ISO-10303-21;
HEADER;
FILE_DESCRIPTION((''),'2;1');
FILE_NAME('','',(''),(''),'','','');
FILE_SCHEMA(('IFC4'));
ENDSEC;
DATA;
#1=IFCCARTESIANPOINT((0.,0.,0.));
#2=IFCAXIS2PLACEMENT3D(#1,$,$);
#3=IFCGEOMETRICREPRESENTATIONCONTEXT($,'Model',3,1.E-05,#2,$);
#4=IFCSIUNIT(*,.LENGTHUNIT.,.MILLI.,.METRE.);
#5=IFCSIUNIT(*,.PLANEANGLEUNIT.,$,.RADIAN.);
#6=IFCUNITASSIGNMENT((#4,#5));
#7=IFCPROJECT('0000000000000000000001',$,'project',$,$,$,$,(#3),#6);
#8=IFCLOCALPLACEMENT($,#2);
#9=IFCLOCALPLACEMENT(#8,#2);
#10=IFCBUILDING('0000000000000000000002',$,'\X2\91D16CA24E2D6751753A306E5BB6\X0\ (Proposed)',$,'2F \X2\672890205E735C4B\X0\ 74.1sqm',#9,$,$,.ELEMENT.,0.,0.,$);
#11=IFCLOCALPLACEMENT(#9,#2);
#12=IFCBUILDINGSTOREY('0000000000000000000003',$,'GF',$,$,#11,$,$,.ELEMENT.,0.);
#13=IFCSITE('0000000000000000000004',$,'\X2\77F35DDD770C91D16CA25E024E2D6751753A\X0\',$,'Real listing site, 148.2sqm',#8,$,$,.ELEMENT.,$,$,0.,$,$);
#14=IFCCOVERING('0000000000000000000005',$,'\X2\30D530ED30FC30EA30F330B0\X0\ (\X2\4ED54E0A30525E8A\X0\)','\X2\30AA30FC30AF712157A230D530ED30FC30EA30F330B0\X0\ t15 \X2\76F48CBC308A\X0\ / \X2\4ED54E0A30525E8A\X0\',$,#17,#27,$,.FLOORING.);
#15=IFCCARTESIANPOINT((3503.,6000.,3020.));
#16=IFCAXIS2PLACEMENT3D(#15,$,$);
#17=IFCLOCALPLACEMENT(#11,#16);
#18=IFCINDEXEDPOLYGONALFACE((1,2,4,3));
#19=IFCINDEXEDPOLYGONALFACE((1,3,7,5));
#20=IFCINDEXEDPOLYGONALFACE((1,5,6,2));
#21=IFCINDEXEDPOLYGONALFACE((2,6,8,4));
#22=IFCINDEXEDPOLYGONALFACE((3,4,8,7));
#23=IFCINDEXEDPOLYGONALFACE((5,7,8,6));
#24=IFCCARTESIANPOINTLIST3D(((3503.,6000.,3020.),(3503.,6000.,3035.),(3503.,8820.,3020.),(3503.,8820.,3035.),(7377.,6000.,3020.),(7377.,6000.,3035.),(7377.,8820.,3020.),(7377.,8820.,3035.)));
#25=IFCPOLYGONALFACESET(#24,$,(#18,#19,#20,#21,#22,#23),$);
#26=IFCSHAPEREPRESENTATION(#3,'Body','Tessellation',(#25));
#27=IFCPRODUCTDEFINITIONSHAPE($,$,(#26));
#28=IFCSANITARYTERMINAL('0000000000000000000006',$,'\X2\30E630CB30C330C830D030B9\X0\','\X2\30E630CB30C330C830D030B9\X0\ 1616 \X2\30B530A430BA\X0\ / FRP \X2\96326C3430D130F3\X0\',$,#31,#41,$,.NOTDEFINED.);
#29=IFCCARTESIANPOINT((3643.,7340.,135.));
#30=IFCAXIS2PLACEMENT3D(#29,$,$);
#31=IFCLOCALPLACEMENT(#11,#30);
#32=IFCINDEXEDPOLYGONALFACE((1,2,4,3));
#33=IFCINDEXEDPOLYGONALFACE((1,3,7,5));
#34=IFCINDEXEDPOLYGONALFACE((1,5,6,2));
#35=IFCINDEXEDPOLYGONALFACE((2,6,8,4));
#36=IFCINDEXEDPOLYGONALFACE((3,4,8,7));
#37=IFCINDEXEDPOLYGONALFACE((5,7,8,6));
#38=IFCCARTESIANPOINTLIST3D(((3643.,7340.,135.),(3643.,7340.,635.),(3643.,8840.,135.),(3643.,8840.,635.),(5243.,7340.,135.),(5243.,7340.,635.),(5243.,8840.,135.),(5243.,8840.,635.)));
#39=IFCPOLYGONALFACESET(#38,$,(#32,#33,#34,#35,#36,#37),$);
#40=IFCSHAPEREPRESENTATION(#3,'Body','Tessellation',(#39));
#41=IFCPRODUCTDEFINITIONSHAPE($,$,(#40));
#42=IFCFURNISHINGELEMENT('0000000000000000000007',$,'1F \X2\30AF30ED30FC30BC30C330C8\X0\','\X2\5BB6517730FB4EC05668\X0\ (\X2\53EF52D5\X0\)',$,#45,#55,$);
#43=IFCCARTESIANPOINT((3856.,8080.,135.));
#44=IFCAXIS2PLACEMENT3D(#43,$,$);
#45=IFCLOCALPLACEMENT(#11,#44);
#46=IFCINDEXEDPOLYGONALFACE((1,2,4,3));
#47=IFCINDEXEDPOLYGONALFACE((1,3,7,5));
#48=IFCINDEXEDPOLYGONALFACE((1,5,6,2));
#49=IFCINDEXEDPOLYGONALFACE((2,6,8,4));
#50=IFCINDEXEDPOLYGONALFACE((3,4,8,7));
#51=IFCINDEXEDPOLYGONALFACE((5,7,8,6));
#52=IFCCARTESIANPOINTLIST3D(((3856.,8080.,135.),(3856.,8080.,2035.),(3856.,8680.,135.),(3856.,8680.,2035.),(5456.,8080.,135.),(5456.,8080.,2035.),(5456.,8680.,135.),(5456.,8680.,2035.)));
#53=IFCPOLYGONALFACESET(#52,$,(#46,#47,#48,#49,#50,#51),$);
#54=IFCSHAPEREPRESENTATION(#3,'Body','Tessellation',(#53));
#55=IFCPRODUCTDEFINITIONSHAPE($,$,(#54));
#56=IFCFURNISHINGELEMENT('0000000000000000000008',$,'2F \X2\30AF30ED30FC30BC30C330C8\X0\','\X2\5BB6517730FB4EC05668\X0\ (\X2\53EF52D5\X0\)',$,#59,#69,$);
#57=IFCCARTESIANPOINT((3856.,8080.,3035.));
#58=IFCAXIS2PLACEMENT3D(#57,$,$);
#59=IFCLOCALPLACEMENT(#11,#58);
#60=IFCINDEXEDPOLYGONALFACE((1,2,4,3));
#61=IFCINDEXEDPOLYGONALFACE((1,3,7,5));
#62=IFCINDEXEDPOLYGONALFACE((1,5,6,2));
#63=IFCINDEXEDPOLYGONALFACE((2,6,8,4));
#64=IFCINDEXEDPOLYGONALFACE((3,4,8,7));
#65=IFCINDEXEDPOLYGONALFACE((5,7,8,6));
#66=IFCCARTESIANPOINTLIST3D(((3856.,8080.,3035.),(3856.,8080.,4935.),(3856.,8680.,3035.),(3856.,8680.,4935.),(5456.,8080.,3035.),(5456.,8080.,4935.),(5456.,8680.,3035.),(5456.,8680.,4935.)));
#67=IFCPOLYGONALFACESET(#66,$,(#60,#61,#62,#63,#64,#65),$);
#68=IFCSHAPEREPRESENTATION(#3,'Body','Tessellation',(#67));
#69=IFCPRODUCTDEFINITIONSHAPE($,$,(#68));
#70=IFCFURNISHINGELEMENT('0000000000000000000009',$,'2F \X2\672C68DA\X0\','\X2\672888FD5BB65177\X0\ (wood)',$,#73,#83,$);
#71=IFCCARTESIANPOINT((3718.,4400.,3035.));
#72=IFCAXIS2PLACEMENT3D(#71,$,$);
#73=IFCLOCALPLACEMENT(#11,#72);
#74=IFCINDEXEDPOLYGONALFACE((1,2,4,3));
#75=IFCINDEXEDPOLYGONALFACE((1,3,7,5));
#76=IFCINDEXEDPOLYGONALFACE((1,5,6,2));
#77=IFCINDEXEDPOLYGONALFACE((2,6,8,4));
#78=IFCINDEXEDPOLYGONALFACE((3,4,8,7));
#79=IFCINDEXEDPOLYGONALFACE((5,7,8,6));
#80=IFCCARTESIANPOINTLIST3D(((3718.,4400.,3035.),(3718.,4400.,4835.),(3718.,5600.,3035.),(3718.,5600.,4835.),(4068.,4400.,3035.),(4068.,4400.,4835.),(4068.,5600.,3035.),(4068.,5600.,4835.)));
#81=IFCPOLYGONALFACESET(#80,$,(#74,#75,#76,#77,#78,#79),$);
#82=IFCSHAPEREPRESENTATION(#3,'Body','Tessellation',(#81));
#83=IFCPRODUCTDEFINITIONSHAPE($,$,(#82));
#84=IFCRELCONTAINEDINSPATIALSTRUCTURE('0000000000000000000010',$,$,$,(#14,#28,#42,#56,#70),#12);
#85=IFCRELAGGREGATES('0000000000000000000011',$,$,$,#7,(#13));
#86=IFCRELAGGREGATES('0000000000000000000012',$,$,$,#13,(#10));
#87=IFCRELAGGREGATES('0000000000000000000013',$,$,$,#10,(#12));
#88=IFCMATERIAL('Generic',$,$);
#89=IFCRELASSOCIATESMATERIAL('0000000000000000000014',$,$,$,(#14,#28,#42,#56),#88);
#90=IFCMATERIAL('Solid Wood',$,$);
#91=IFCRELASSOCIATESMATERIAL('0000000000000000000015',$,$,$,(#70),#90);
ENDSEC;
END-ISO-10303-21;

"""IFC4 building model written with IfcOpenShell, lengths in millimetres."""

from ifc_helpers import new_model, si_unit, frame, frame_2d, origin, place, context, project, spatial, rectangle, extrude, material, element, save


model = new_model("IFC4")

# Units and contexts
model_context = context("Model", 3, precision=1e-05, world=origin())
ifc_project = project(units=[si_unit("LENGTHUNIT", "METRE", prefix="MILLI"), si_unit("PLANEANGLEUNIT", "RADIAN")], contexts=[model_context])

# Site, building, storey
site_placement = place(None, origin())
site = spatial("IfcSite", under=ifc_project, at=site_placement, Name="石川県金沢市中村町", ObjectType="Real listing site, 148.2sqm", CompositionType="ELEMENT", RefElevation=0.0)
building_placement = place(site_placement, origin())
building = spatial("IfcBuilding", under=site, at=building_placement, Name="金沢中村町の家 (Proposed)", ObjectType="2F 木造平屋 74.1sqm", CompositionType="ELEMENT", ElevationOfRefHeight=0.0, ElevationOfTerrain=0.0)
storey_placement = place(building_placement, origin())
storey = spatial("IfcBuildingStorey", under=building, at=storey_placement, Name="GF", CompositionType="ELEMENT", Elevation=0.0)

# Shared definitions
ifc_material_1 = material(Name="Solid Wood")

# Covering
ifc_material_2 = material(Name="Generic")
covering_1_placement = place(storey_placement, frame((3503.0, 6000.0, 3020.0)))
element("IfcCovering", 1, at=covering_1_placement, inside=storey, material=ifc_material_2, Name="フローリング (仕上げ床)", Description="オーク無垢フローリング t15 直貼り / 仕上げ床", PredefinedType="FLOORING", context=model_context, shape_type="SweptSolid", body=[
    extrude(rectangle(XDim=3874.0, YDim=2820.0, at=frame_2d((1937.0, 1410.0))), frame((3503.0, 6000.0, 3020.0)), (0.0, 0.0, 1.0), 15.0),
])

# Sanitary terminal
sanitary_terminal_placement = place(storey_placement, frame((3643.0, 7340.0, 135.0)))
element("IfcSanitaryTerminal", 2, at=sanitary_terminal_placement, inside=storey, material=ifc_material_2, Name="ユニットバス", Description="ユニットバス 1616 サイズ / FRP 防水パン", PredefinedType="NOTDEFINED", context=model_context, shape_type="SweptSolid", body=[
    extrude(rectangle(XDim=1600.0, YDim=1500.0, at=frame_2d((800.0, 750.0))), frame((3643.0, 7340.0, 135.0)), (0.0, 0.0, 1.0), 500.0),
])

# Furnishing elements
furnishing_1_placement = place(storey_placement, frame((3856.0, 8080.0, 135.0)))
element("IfcFurnishingElement", 3, at=furnishing_1_placement, inside=storey, material=ifc_material_2, Name="1F クローゼット", Description="家具・什器 (可動)", context=model_context, shape_type="SweptSolid", body=[
    extrude(rectangle(XDim=1600.0, YDim=600.0, at=frame_2d((800.0, 300.0))), frame((3856.0, 8080.0, 135.0)), (0.0, 0.0, 1.0), 1900.0),
])
furnishing_2_placement = place(storey_placement, frame((3856.0, 8080.0, 3035.0)))
element("IfcFurnishingElement", 4, at=furnishing_2_placement, inside=storey, material=ifc_material_2, Name="2F クローゼット", Description="家具・什器 (可動)", context=model_context, shape_type="SweptSolid", body=[
    extrude(rectangle(XDim=1600.0, YDim=600.0, at=frame_2d((800.0, 300.0))), frame((3856.0, 8080.0, 3035.0)), (0.0, 0.0, 1.0), 1900.0),
])
furnishing_3_placement = place(storey_placement, frame((3718.0, 4400.0, 3035.0)))
element("IfcFurnishingElement", 5, at=furnishing_3_placement, inside=storey, material=ifc_material_1, Name="2F 本棚", Description="木製家具 (wood)", context=model_context, shape_type="SweptSolid", body=[
    extrude(rectangle(XDim=350.0, YDim=1200.0, at=frame_2d((175.0, 600.0))), frame((3718.0, 4400.0, 3035.0)), (0.0, 0.0, 1.0), 1800.0),
])

save(model, "model.ifc")
